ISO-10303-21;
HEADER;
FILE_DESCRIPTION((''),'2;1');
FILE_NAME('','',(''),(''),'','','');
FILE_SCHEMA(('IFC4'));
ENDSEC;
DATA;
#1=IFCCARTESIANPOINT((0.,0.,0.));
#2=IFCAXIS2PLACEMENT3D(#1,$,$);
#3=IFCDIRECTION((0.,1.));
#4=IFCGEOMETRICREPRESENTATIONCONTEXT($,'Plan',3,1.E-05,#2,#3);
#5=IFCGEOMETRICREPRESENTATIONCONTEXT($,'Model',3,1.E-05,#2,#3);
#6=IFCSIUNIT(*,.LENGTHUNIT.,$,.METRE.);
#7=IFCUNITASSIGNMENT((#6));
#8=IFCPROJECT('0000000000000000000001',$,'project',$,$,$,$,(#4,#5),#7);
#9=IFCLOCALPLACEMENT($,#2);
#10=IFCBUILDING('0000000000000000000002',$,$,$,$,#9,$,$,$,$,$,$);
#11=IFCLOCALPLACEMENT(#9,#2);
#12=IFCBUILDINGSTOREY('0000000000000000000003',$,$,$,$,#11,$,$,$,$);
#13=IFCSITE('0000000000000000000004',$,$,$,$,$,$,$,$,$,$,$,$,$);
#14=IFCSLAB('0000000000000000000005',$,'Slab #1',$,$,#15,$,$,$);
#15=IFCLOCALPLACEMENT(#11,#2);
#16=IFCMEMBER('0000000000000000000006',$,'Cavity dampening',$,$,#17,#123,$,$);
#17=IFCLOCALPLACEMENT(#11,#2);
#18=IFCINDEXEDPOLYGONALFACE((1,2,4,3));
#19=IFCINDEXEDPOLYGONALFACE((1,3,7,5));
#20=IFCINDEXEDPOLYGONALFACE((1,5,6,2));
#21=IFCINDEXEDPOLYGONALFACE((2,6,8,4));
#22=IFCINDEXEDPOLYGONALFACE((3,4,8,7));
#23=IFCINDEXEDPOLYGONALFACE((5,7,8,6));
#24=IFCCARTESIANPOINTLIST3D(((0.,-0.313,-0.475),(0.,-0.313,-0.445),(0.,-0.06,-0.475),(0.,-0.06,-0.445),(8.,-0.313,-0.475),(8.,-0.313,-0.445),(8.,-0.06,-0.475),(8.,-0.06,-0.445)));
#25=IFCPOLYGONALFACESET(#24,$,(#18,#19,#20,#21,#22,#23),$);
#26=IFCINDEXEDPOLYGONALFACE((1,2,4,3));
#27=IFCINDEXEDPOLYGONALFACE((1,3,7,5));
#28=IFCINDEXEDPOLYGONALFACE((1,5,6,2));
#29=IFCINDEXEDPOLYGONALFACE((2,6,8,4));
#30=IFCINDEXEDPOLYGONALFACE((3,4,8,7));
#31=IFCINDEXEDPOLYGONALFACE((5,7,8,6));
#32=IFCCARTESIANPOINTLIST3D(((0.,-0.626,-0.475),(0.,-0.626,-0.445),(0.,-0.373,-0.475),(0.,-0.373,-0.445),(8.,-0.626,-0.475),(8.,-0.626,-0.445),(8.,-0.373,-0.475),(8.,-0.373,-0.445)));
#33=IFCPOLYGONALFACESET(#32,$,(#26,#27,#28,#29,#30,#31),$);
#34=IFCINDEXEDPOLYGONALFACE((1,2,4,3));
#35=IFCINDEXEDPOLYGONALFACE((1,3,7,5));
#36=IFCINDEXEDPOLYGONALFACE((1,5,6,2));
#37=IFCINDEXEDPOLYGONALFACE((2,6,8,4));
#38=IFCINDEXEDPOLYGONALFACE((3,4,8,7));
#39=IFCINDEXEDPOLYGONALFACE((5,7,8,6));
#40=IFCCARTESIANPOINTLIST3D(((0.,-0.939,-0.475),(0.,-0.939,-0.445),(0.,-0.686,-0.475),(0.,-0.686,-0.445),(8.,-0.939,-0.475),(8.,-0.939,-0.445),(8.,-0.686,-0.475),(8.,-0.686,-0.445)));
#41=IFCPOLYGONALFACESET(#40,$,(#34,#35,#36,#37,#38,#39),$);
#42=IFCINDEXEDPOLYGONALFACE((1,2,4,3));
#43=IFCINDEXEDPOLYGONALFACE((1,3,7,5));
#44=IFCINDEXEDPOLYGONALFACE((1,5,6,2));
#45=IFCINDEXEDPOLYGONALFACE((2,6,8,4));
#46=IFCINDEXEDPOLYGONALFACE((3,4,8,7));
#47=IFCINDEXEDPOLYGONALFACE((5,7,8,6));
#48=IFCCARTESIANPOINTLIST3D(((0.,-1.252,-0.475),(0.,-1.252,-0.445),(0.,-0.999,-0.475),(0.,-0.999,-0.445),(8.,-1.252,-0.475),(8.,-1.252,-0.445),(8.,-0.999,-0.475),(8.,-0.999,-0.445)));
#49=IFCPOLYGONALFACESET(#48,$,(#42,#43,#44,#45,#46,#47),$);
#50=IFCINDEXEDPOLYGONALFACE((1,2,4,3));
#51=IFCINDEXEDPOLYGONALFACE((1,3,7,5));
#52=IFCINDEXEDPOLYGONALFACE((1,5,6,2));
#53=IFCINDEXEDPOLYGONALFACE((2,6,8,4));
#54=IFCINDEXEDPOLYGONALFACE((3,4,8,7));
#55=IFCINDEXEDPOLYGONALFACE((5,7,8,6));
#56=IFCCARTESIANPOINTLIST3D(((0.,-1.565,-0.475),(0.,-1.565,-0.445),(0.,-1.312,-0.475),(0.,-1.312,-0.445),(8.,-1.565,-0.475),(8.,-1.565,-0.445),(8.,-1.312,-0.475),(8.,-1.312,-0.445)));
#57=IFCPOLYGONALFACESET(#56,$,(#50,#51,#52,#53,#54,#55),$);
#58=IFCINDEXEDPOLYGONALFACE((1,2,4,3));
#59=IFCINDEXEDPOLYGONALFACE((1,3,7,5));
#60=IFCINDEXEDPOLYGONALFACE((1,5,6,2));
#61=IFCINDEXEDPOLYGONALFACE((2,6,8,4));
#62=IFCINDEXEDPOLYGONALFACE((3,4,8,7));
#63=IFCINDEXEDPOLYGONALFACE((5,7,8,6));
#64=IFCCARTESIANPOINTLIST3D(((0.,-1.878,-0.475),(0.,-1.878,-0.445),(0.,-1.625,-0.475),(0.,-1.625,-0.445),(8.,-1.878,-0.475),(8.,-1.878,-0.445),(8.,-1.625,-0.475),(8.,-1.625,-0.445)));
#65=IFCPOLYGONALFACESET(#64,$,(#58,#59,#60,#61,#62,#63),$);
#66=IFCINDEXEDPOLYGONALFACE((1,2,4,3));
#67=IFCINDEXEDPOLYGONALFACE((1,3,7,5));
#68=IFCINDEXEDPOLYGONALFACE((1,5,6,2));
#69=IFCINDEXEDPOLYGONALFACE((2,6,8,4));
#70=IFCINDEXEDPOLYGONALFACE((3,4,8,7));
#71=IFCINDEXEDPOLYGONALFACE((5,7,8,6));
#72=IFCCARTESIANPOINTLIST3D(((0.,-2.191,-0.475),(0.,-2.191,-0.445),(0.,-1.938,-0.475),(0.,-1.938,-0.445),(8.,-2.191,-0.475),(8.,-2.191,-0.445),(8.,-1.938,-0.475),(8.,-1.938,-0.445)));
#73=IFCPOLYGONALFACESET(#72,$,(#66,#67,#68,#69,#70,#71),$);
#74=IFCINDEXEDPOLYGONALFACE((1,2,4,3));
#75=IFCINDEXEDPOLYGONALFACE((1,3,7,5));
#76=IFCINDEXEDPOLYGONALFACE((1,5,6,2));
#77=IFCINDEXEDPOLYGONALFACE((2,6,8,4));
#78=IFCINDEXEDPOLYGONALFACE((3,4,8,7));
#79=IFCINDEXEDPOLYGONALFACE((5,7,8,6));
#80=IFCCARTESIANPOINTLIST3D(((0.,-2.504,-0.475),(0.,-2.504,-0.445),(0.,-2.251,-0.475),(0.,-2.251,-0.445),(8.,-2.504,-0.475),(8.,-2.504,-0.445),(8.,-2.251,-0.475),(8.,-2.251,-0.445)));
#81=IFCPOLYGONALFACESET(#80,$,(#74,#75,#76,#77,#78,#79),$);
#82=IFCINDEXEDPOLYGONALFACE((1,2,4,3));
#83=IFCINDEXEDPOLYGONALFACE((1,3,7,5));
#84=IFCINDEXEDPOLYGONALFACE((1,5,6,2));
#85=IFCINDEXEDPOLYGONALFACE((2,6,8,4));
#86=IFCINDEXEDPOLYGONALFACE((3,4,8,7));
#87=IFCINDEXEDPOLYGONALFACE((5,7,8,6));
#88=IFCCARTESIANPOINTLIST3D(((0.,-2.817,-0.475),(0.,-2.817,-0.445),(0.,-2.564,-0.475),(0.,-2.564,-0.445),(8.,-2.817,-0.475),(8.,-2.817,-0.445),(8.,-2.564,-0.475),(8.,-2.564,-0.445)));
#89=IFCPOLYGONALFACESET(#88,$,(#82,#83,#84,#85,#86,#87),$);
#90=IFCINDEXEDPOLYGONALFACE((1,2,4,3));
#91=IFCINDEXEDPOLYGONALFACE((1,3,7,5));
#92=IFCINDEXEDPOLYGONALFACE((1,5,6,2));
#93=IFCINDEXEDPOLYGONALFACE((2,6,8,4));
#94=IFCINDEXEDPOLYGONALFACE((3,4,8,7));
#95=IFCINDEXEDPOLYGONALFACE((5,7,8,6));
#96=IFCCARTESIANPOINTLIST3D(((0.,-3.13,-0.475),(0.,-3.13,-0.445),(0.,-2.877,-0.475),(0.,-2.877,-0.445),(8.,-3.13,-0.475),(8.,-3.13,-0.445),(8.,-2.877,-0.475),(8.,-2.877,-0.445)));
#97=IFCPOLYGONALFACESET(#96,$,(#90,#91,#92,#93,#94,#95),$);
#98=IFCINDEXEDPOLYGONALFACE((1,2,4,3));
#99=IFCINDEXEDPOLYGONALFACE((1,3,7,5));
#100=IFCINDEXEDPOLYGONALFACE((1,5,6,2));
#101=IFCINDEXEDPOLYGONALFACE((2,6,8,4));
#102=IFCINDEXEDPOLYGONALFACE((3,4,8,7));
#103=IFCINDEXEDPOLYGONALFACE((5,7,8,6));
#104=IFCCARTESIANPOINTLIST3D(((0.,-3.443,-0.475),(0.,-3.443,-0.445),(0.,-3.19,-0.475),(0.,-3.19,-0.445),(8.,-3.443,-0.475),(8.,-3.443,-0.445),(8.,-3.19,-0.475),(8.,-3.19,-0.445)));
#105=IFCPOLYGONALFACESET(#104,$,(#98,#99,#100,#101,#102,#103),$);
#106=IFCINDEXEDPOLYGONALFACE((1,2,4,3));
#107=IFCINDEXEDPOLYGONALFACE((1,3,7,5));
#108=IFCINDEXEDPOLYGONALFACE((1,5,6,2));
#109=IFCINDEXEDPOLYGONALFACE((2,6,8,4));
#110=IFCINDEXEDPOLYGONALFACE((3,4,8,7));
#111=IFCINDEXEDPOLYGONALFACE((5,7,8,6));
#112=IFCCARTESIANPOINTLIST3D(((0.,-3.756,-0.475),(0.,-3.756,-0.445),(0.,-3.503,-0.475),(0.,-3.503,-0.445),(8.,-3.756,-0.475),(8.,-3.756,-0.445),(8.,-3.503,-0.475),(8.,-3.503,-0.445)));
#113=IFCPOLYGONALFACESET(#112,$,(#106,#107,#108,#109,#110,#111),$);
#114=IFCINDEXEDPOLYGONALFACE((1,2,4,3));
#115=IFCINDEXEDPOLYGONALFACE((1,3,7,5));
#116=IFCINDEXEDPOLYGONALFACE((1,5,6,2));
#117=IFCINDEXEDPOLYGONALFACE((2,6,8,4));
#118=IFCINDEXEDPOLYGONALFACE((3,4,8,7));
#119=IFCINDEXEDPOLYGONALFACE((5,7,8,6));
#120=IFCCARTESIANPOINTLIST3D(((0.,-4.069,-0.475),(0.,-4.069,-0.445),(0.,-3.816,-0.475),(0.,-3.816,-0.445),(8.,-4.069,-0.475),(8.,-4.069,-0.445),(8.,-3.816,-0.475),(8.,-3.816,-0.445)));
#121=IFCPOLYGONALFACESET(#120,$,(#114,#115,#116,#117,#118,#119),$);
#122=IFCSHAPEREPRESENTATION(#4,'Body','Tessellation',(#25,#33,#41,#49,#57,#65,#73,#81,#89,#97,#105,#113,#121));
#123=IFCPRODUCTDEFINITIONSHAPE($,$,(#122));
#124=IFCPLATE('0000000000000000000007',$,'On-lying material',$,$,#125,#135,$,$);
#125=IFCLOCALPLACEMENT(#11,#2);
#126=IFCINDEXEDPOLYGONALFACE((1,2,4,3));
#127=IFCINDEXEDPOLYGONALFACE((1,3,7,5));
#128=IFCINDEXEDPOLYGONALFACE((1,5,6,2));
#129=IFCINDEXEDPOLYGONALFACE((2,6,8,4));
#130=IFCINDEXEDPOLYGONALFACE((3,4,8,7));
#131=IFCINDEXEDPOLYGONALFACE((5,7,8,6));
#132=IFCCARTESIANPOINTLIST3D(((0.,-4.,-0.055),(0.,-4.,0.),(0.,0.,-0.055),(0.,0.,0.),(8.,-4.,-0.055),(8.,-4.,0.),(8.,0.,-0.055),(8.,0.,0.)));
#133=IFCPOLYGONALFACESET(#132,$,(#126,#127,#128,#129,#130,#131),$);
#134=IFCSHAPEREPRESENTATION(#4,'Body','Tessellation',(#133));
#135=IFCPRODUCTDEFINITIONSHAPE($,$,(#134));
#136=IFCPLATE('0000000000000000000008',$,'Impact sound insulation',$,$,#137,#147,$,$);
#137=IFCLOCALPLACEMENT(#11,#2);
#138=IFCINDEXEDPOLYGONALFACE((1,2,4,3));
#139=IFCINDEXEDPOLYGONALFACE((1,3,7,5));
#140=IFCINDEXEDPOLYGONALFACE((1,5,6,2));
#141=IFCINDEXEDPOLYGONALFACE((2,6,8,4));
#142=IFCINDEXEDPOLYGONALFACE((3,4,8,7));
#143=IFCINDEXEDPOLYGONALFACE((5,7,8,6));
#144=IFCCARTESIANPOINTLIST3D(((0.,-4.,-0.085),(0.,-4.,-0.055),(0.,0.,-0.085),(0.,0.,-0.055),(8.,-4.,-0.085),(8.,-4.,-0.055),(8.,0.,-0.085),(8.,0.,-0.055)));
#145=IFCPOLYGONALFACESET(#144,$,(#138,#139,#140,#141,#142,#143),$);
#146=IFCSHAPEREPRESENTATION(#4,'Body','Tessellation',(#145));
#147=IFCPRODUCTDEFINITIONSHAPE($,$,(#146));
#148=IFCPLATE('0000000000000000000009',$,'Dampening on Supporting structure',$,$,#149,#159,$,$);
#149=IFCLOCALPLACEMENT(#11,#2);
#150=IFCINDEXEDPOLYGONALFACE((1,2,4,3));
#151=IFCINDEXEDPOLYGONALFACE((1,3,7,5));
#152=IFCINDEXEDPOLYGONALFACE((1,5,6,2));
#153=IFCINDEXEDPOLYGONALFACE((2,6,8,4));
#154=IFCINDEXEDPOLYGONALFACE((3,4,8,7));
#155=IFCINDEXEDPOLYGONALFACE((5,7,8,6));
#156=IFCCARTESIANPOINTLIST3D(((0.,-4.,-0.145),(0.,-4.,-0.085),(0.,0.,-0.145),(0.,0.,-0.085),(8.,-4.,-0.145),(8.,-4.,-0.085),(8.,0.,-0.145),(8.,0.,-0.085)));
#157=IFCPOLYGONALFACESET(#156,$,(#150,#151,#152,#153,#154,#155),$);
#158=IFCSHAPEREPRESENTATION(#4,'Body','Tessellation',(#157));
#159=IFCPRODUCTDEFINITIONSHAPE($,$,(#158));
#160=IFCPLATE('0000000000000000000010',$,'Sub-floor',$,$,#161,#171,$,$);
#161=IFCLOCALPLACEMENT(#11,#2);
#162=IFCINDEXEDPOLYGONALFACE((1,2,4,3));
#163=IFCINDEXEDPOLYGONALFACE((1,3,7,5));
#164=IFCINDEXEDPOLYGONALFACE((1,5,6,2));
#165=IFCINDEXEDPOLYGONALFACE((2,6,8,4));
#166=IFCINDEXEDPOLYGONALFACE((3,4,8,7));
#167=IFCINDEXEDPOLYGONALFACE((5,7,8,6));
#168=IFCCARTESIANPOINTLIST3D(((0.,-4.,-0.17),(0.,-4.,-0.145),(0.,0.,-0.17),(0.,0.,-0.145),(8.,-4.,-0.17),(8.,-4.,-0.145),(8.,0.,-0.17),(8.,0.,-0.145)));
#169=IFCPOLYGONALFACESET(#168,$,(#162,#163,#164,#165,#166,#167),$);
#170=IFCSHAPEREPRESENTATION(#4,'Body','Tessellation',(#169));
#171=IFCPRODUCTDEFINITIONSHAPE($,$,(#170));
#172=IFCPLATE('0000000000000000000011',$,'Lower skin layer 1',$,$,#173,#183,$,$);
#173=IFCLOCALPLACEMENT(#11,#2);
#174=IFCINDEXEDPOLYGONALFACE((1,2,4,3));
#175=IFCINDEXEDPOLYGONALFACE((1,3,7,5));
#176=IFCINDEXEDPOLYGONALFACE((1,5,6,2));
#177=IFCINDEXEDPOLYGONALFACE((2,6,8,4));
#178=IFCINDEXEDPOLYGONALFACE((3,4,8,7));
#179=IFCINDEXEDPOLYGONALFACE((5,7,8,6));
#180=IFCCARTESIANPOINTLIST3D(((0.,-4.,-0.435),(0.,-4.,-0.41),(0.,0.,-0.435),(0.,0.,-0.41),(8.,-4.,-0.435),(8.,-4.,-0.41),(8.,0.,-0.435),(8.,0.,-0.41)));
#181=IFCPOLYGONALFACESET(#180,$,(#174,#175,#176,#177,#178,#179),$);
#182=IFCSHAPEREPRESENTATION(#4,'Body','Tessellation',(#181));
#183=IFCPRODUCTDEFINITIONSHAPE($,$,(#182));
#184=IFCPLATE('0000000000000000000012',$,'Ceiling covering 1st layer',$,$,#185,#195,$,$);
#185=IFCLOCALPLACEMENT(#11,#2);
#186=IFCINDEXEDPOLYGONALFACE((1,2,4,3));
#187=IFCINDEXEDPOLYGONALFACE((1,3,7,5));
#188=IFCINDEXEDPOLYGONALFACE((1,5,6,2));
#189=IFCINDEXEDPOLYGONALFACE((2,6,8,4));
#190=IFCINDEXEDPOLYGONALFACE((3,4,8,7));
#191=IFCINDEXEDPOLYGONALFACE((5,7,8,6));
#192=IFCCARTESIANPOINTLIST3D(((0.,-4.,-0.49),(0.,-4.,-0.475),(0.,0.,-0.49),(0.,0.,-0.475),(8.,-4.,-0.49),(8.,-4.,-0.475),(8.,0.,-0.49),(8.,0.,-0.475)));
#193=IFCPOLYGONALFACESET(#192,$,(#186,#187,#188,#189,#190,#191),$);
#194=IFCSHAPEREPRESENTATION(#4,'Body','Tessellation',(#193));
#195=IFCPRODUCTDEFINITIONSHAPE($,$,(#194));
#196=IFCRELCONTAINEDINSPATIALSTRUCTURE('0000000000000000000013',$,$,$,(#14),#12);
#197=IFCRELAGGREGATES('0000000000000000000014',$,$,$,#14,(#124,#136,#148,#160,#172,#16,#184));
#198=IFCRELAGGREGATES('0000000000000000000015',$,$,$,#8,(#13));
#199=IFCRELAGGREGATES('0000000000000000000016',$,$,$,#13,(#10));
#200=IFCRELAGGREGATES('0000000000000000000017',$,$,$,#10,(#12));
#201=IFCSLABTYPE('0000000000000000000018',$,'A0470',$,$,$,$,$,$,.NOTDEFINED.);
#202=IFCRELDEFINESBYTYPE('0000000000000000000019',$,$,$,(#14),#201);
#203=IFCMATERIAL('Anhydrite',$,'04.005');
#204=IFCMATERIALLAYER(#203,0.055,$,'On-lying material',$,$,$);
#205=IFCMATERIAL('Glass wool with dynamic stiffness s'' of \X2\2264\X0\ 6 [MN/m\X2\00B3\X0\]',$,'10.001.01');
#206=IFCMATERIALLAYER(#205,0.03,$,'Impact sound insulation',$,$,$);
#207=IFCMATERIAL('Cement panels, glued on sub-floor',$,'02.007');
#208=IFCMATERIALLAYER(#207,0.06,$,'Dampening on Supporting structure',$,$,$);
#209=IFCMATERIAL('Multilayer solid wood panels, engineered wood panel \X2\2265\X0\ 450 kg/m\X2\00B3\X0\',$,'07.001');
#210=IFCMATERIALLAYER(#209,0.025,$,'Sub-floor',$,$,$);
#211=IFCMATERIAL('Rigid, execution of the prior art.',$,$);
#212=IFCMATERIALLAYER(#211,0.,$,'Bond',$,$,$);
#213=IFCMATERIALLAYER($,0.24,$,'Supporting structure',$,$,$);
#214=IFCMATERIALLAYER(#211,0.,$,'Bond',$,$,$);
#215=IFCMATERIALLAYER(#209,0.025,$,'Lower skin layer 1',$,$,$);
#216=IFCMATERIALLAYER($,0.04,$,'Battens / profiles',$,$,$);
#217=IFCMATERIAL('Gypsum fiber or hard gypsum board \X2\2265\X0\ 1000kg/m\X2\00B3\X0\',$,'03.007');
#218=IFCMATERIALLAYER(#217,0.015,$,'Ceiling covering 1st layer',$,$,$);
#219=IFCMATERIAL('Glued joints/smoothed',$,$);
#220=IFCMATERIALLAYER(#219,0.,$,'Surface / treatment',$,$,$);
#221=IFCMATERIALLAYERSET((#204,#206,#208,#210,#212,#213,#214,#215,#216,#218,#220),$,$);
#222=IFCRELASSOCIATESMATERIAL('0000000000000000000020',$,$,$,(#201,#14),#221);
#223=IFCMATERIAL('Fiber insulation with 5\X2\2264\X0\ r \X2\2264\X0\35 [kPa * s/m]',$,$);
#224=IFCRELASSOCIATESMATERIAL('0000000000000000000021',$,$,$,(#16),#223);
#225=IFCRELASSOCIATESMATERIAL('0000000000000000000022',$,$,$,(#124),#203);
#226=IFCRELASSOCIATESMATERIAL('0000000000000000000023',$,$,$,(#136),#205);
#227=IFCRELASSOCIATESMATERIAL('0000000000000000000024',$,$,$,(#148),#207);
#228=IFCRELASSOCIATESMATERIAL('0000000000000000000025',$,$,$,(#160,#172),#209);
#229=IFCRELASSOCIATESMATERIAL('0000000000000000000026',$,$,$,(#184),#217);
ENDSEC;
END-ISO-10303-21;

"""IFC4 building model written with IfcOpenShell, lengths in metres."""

from ifc_helpers import new_model, si_unit, direction, frame, frame_2d, origin, origin_with_axes, place, context, project, spatial, rectangle, extrude, material, layer, layer_set, type_object, element, aggregate, save


model = new_model("IFC4")

# Units and contexts
plan_context = context("Plan", 3, precision=1e-05, world=origin(), true_north=direction((0.0, 1.0)))
model_context = context("Model", 3, precision=1e-05, world=origin(), true_north=direction((0.0, 1.0)))
ifc_project = project(units=[si_unit("LENGTHUNIT", "METRE")], contexts=[plan_context, model_context])

# Site, building, storey
site = spatial("IfcSite", under=ifc_project)
building_placement = place(None, origin())
building = spatial("IfcBuilding", under=site, at=building_placement)
storey_placement = place(building_placement, origin())
storey = spatial("IfcBuildingStorey", under=building, at=storey_placement)

# Slab, member, plates
ifc_material_1 = material(Name="Anhydrite", Category="04.005")
ifc_layer_1 = layer(ifc_material_1, 0.055, Name="On-lying material")
ifc_material_2 = material(Name="Glass wool with dynamic stiffness s' of ≤ 6 [MN/m³]", Category="10.001.01")
ifc_layer_2 = layer(ifc_material_2, 0.03, Name="Impact sound insulation")
ifc_material_3 = material(Name="Cement panels, glued on sub-floor", Category="02.007")
ifc_layer_3 = layer(ifc_material_3, 0.06, Name="Dampening on Supporting structure")
ifc_material_4 = material(Name="Multilayer solid wood panels, engineered wood panel ≥ 450 kg/m³", Category="07.001")
ifc_layer_4 = layer(ifc_material_4, 0.025, Name="Sub-floor")
ifc_material_5 = material(Name="Rigid, execution of the prior art.")
ifc_layer_5 = layer(ifc_material_5, 0.0, Name="Bond")
ifc_layer_6 = layer(None, 0.24, Name="Supporting structure")
ifc_layer_7 = layer(ifc_material_5, 0.0, Name="Bond")
ifc_layer_8 = layer(ifc_material_4, 0.025, Name="Lower skin layer 1")
ifc_layer_9 = layer(None, 0.04, Name="Battens / profiles")
ifc_material_6 = material(Name="Gypsum fiber or hard gypsum board ≥ 1000kg/m³", Category="03.007")
ifc_layer_10 = layer(ifc_material_6, 0.015, Name="Ceiling covering 1st layer")
ifc_material_7 = material(Name="Glued joints/smoothed")
ifc_layer_11 = layer(ifc_material_7, 0.0, Name="Surface / treatment")
ifc_layer_set = layer_set([ifc_layer_1, ifc_layer_2, ifc_layer_3, ifc_layer_4, ifc_layer_5, ifc_layer_6, ifc_layer_7, ifc_layer_8, ifc_layer_9, ifc_layer_10, ifc_layer_11])
slab_type = type_object("IfcSlabType", Name="A0470", PredefinedType="NOTDEFINED", material=ifc_layer_set)
slab_placement = place(None, frame((0.0, 0.0, 0.0), z_axis=(0.0, 0.0, -1.0), x_axis=(1.0, 0.0, 0.0)))
slab = element("IfcSlab", 1, at=slab_placement, inside=storey, type_object=slab_type, material=ifc_layer_set, Name="Slab #1")
ifc_material_8 = material(Name="Fiber insulation with 5≤ r ≤35 [kPa * s/m]")
member_1_placement = place(slab_placement, origin())
member_1 = element("IfcMember", 2, at=member_1_placement, material=ifc_material_8, Name="Cavity dampening", context=plan_context, shape_type="SweptSolid", body=[
    extrude(rectangle(XDim=0.253, YDim=0.03, at=frame_2d((0.1265, 0.015), x_axis=(1.0, 0.0))), frame((0.0, 0.06, 0.445), z_axis=(1.0, 0.0, 0.0), x_axis=(0.0, 1.0, 0.0)), (0.0, 0.0, 1.0), 8.0),
    extrude(rectangle(XDim=0.253, YDim=0.03, at=frame_2d((0.1265, 0.015), x_axis=(1.0, 0.0))), frame((0.0, 0.373, 0.445), z_axis=(1.0, 0.0, 0.0), x_axis=(0.0, 1.0, 0.0)), (0.0, 0.0, 1.0), 8.0),
    extrude(rectangle(XDim=0.253, YDim=0.03, at=frame_2d((0.1265, 0.015), x_axis=(1.0, 0.0))), frame((0.0, 0.686, 0.445), z_axis=(1.0, 0.0, 0.0), x_axis=(0.0, 1.0, 0.0)), (0.0, 0.0, 1.0), 8.0),
    extrude(rectangle(XDim=0.253, YDim=0.03, at=frame_2d((0.1265, 0.015), x_axis=(1.0, 0.0))), frame((0.0, 0.999, 0.445), z_axis=(1.0, 0.0, 0.0), x_axis=(0.0, 1.0, 0.0)), (0.0, 0.0, 1.0), 8.0),
    extrude(rectangle(XDim=0.253, YDim=0.03, at=frame_2d((0.1265, 0.015), x_axis=(1.0, 0.0))), frame((0.0, 1.312, 0.445), z_axis=(1.0, 0.0, 0.0), x_axis=(0.0, 1.0, 0.0)), (0.0, 0.0, 1.0), 8.0),
    extrude(rectangle(XDim=0.253, YDim=0.03, at=frame_2d((0.1265, 0.015), x_axis=(1.0, 0.0))), frame((0.0, 1.625, 0.445), z_axis=(1.0, 0.0, 0.0), x_axis=(0.0, 1.0, 0.0)), (0.0, 0.0, 1.0), 8.0),
    extrude(rectangle(XDim=0.253, YDim=0.03, at=frame_2d((0.1265, 0.015), x_axis=(1.0, 0.0))), frame((0.0, 1.938, 0.445), z_axis=(1.0, 0.0, 0.0), x_axis=(0.0, 1.0, 0.0)), (0.0, 0.0, 1.0), 8.0),
    extrude(rectangle(XDim=0.253, YDim=0.03, at=frame_2d((0.1265, 0.015), x_axis=(1.0, 0.0))), frame((0.0, 2.251, 0.445), z_axis=(1.0, 0.0, 0.0), x_axis=(0.0, 1.0, 0.0)), (0.0, 0.0, 1.0), 8.0),
    extrude(rectangle(XDim=0.253, YDim=0.03, at=frame_2d((0.1265, 0.015), x_axis=(1.0, 0.0))), frame((0.0, 2.564, 0.445), z_axis=(1.0, 0.0, 0.0), x_axis=(0.0, 1.0, 0.0)), (0.0, 0.0, 1.0), 8.0),
    extrude(rectangle(XDim=0.253, YDim=0.03, at=frame_2d((0.1265, 0.015), x_axis=(1.0, 0.0))), frame((0.0, 2.877, 0.445), z_axis=(1.0, 0.0, 0.0), x_axis=(0.0, 1.0, 0.0)), (0.0, 0.0, 1.0), 8.0),
    extrude(rectangle(XDim=0.253, YDim=0.03, at=frame_2d((0.1265, 0.015), x_axis=(1.0, 0.0))), frame((0.0, 3.19, 0.445), z_axis=(1.0, 0.0, 0.0), x_axis=(0.0, 1.0, 0.0)), (0.0, 0.0, 1.0), 8.0),
    extrude(rectangle(XDim=0.253, YDim=0.03, at=frame_2d((0.1265, 0.015), x_axis=(1.0, 0.0))), frame((0.0, 3.503, 0.445), z_axis=(1.0, 0.0, 0.0), x_axis=(0.0, 1.0, 0.0)), (0.0, 0.0, 1.0), 8.0),
    extrude(rectangle(XDim=0.253, YDim=0.03, at=frame_2d((0.1265, 0.015), x_axis=(1.0, 0.0))), frame((0.0, 3.816, 0.445), z_axis=(1.0, 0.0, 0.0), x_axis=(0.0, 1.0, 0.0)), (0.0, 0.0, 1.0), 8.0),
])
plate_1_placement = place(slab_placement, origin())
plate_1 = element("IfcPlate", 3, at=plate_1_placement, material=ifc_material_1, Name="On-lying material", context=plan_context, shape_type="SweptSolid", body=[
    extrude(rectangle(XDim=8.0, YDim=4.0, at=frame_2d((4.0, 2.0), x_axis=(1.0, 0.0))), origin_with_axes(), (0.0, 0.0, 1.0), 0.055),
])
plate_2_placement = place(slab_placement, origin())
plate_2 = element("IfcPlate", 4, at=plate_2_placement, material=ifc_material_2, Name="Impact sound insulation", context=plan_context, shape_type="SweptSolid", body=[
    extrude(rectangle(XDim=8.0, YDim=4.0, at=frame_2d((4.0, 2.0), x_axis=(1.0, 0.0))), frame((0.0, 0.0, 0.055), z_axis=(0.0, 0.0, 1.0), x_axis=(1.0, 0.0, 0.0)), (0.0, 0.0, 1.0), 0.03),
])
plate_3_placement = place(slab_placement, origin())
plate_3 = element("IfcPlate", 5, at=plate_3_placement, material=ifc_material_3, Name="Dampening on Supporting structure", context=plan_context, shape_type="SweptSolid", body=[
    extrude(rectangle(XDim=8.0, YDim=4.0, at=frame_2d((4.0, 2.0), x_axis=(1.0, 0.0))), frame((0.0, 0.0, 0.085), z_axis=(0.0, 0.0, 1.0), x_axis=(1.0, 0.0, 0.0)), (0.0, 0.0, 1.0), 0.06),
])
plate_4_placement = place(slab_placement, origin())
plate_4 = element("IfcPlate", 6, at=plate_4_placement, material=ifc_material_4, Name="Sub-floor", context=plan_context, shape_type="SweptSolid", body=[
    extrude(rectangle(XDim=8.0, YDim=4.0, at=frame_2d((4.0, 2.0), x_axis=(1.0, 0.0))), frame((0.0, 0.0, 0.145), z_axis=(0.0, 0.0, 1.0), x_axis=(1.0, 0.0, 0.0)), (0.0, 0.0, 1.0), 0.025),
])
plate_5_placement = place(slab_placement, origin())
plate_5 = element("IfcPlate", 7, at=plate_5_placement, material=ifc_material_4, Name="Lower skin layer 1", context=plan_context, shape_type="SweptSolid", body=[
    extrude(rectangle(XDim=8.0, YDim=4.0, at=frame_2d((4.0, 2.0), x_axis=(1.0, 0.0))), frame((0.0, 0.0, 0.41), z_axis=(0.0, 0.0, 1.0), x_axis=(1.0, 0.0, 0.0)), (0.0, 0.0, 1.0), 0.025),
])
plate_6_placement = place(slab_placement, origin())
plate_6 = element("IfcPlate", 8, at=plate_6_placement, material=ifc_material_6, Name="Ceiling covering 1st layer", context=plan_context, shape_type="SweptSolid", body=[
    extrude(rectangle(XDim=8.0, YDim=4.0, at=frame_2d((4.0, 2.0), x_axis=(1.0, 0.0))), frame((0.0, 0.0, 0.475), z_axis=(0.0, 0.0, 1.0), x_axis=(1.0, 0.0, 0.0)), (0.0, 0.0, 1.0), 0.015),
])
aggregate(slab, [plate_1, plate_2, plate_3, plate_4, plate_5, member_1, plate_6])

save(model, "model.ifc")
